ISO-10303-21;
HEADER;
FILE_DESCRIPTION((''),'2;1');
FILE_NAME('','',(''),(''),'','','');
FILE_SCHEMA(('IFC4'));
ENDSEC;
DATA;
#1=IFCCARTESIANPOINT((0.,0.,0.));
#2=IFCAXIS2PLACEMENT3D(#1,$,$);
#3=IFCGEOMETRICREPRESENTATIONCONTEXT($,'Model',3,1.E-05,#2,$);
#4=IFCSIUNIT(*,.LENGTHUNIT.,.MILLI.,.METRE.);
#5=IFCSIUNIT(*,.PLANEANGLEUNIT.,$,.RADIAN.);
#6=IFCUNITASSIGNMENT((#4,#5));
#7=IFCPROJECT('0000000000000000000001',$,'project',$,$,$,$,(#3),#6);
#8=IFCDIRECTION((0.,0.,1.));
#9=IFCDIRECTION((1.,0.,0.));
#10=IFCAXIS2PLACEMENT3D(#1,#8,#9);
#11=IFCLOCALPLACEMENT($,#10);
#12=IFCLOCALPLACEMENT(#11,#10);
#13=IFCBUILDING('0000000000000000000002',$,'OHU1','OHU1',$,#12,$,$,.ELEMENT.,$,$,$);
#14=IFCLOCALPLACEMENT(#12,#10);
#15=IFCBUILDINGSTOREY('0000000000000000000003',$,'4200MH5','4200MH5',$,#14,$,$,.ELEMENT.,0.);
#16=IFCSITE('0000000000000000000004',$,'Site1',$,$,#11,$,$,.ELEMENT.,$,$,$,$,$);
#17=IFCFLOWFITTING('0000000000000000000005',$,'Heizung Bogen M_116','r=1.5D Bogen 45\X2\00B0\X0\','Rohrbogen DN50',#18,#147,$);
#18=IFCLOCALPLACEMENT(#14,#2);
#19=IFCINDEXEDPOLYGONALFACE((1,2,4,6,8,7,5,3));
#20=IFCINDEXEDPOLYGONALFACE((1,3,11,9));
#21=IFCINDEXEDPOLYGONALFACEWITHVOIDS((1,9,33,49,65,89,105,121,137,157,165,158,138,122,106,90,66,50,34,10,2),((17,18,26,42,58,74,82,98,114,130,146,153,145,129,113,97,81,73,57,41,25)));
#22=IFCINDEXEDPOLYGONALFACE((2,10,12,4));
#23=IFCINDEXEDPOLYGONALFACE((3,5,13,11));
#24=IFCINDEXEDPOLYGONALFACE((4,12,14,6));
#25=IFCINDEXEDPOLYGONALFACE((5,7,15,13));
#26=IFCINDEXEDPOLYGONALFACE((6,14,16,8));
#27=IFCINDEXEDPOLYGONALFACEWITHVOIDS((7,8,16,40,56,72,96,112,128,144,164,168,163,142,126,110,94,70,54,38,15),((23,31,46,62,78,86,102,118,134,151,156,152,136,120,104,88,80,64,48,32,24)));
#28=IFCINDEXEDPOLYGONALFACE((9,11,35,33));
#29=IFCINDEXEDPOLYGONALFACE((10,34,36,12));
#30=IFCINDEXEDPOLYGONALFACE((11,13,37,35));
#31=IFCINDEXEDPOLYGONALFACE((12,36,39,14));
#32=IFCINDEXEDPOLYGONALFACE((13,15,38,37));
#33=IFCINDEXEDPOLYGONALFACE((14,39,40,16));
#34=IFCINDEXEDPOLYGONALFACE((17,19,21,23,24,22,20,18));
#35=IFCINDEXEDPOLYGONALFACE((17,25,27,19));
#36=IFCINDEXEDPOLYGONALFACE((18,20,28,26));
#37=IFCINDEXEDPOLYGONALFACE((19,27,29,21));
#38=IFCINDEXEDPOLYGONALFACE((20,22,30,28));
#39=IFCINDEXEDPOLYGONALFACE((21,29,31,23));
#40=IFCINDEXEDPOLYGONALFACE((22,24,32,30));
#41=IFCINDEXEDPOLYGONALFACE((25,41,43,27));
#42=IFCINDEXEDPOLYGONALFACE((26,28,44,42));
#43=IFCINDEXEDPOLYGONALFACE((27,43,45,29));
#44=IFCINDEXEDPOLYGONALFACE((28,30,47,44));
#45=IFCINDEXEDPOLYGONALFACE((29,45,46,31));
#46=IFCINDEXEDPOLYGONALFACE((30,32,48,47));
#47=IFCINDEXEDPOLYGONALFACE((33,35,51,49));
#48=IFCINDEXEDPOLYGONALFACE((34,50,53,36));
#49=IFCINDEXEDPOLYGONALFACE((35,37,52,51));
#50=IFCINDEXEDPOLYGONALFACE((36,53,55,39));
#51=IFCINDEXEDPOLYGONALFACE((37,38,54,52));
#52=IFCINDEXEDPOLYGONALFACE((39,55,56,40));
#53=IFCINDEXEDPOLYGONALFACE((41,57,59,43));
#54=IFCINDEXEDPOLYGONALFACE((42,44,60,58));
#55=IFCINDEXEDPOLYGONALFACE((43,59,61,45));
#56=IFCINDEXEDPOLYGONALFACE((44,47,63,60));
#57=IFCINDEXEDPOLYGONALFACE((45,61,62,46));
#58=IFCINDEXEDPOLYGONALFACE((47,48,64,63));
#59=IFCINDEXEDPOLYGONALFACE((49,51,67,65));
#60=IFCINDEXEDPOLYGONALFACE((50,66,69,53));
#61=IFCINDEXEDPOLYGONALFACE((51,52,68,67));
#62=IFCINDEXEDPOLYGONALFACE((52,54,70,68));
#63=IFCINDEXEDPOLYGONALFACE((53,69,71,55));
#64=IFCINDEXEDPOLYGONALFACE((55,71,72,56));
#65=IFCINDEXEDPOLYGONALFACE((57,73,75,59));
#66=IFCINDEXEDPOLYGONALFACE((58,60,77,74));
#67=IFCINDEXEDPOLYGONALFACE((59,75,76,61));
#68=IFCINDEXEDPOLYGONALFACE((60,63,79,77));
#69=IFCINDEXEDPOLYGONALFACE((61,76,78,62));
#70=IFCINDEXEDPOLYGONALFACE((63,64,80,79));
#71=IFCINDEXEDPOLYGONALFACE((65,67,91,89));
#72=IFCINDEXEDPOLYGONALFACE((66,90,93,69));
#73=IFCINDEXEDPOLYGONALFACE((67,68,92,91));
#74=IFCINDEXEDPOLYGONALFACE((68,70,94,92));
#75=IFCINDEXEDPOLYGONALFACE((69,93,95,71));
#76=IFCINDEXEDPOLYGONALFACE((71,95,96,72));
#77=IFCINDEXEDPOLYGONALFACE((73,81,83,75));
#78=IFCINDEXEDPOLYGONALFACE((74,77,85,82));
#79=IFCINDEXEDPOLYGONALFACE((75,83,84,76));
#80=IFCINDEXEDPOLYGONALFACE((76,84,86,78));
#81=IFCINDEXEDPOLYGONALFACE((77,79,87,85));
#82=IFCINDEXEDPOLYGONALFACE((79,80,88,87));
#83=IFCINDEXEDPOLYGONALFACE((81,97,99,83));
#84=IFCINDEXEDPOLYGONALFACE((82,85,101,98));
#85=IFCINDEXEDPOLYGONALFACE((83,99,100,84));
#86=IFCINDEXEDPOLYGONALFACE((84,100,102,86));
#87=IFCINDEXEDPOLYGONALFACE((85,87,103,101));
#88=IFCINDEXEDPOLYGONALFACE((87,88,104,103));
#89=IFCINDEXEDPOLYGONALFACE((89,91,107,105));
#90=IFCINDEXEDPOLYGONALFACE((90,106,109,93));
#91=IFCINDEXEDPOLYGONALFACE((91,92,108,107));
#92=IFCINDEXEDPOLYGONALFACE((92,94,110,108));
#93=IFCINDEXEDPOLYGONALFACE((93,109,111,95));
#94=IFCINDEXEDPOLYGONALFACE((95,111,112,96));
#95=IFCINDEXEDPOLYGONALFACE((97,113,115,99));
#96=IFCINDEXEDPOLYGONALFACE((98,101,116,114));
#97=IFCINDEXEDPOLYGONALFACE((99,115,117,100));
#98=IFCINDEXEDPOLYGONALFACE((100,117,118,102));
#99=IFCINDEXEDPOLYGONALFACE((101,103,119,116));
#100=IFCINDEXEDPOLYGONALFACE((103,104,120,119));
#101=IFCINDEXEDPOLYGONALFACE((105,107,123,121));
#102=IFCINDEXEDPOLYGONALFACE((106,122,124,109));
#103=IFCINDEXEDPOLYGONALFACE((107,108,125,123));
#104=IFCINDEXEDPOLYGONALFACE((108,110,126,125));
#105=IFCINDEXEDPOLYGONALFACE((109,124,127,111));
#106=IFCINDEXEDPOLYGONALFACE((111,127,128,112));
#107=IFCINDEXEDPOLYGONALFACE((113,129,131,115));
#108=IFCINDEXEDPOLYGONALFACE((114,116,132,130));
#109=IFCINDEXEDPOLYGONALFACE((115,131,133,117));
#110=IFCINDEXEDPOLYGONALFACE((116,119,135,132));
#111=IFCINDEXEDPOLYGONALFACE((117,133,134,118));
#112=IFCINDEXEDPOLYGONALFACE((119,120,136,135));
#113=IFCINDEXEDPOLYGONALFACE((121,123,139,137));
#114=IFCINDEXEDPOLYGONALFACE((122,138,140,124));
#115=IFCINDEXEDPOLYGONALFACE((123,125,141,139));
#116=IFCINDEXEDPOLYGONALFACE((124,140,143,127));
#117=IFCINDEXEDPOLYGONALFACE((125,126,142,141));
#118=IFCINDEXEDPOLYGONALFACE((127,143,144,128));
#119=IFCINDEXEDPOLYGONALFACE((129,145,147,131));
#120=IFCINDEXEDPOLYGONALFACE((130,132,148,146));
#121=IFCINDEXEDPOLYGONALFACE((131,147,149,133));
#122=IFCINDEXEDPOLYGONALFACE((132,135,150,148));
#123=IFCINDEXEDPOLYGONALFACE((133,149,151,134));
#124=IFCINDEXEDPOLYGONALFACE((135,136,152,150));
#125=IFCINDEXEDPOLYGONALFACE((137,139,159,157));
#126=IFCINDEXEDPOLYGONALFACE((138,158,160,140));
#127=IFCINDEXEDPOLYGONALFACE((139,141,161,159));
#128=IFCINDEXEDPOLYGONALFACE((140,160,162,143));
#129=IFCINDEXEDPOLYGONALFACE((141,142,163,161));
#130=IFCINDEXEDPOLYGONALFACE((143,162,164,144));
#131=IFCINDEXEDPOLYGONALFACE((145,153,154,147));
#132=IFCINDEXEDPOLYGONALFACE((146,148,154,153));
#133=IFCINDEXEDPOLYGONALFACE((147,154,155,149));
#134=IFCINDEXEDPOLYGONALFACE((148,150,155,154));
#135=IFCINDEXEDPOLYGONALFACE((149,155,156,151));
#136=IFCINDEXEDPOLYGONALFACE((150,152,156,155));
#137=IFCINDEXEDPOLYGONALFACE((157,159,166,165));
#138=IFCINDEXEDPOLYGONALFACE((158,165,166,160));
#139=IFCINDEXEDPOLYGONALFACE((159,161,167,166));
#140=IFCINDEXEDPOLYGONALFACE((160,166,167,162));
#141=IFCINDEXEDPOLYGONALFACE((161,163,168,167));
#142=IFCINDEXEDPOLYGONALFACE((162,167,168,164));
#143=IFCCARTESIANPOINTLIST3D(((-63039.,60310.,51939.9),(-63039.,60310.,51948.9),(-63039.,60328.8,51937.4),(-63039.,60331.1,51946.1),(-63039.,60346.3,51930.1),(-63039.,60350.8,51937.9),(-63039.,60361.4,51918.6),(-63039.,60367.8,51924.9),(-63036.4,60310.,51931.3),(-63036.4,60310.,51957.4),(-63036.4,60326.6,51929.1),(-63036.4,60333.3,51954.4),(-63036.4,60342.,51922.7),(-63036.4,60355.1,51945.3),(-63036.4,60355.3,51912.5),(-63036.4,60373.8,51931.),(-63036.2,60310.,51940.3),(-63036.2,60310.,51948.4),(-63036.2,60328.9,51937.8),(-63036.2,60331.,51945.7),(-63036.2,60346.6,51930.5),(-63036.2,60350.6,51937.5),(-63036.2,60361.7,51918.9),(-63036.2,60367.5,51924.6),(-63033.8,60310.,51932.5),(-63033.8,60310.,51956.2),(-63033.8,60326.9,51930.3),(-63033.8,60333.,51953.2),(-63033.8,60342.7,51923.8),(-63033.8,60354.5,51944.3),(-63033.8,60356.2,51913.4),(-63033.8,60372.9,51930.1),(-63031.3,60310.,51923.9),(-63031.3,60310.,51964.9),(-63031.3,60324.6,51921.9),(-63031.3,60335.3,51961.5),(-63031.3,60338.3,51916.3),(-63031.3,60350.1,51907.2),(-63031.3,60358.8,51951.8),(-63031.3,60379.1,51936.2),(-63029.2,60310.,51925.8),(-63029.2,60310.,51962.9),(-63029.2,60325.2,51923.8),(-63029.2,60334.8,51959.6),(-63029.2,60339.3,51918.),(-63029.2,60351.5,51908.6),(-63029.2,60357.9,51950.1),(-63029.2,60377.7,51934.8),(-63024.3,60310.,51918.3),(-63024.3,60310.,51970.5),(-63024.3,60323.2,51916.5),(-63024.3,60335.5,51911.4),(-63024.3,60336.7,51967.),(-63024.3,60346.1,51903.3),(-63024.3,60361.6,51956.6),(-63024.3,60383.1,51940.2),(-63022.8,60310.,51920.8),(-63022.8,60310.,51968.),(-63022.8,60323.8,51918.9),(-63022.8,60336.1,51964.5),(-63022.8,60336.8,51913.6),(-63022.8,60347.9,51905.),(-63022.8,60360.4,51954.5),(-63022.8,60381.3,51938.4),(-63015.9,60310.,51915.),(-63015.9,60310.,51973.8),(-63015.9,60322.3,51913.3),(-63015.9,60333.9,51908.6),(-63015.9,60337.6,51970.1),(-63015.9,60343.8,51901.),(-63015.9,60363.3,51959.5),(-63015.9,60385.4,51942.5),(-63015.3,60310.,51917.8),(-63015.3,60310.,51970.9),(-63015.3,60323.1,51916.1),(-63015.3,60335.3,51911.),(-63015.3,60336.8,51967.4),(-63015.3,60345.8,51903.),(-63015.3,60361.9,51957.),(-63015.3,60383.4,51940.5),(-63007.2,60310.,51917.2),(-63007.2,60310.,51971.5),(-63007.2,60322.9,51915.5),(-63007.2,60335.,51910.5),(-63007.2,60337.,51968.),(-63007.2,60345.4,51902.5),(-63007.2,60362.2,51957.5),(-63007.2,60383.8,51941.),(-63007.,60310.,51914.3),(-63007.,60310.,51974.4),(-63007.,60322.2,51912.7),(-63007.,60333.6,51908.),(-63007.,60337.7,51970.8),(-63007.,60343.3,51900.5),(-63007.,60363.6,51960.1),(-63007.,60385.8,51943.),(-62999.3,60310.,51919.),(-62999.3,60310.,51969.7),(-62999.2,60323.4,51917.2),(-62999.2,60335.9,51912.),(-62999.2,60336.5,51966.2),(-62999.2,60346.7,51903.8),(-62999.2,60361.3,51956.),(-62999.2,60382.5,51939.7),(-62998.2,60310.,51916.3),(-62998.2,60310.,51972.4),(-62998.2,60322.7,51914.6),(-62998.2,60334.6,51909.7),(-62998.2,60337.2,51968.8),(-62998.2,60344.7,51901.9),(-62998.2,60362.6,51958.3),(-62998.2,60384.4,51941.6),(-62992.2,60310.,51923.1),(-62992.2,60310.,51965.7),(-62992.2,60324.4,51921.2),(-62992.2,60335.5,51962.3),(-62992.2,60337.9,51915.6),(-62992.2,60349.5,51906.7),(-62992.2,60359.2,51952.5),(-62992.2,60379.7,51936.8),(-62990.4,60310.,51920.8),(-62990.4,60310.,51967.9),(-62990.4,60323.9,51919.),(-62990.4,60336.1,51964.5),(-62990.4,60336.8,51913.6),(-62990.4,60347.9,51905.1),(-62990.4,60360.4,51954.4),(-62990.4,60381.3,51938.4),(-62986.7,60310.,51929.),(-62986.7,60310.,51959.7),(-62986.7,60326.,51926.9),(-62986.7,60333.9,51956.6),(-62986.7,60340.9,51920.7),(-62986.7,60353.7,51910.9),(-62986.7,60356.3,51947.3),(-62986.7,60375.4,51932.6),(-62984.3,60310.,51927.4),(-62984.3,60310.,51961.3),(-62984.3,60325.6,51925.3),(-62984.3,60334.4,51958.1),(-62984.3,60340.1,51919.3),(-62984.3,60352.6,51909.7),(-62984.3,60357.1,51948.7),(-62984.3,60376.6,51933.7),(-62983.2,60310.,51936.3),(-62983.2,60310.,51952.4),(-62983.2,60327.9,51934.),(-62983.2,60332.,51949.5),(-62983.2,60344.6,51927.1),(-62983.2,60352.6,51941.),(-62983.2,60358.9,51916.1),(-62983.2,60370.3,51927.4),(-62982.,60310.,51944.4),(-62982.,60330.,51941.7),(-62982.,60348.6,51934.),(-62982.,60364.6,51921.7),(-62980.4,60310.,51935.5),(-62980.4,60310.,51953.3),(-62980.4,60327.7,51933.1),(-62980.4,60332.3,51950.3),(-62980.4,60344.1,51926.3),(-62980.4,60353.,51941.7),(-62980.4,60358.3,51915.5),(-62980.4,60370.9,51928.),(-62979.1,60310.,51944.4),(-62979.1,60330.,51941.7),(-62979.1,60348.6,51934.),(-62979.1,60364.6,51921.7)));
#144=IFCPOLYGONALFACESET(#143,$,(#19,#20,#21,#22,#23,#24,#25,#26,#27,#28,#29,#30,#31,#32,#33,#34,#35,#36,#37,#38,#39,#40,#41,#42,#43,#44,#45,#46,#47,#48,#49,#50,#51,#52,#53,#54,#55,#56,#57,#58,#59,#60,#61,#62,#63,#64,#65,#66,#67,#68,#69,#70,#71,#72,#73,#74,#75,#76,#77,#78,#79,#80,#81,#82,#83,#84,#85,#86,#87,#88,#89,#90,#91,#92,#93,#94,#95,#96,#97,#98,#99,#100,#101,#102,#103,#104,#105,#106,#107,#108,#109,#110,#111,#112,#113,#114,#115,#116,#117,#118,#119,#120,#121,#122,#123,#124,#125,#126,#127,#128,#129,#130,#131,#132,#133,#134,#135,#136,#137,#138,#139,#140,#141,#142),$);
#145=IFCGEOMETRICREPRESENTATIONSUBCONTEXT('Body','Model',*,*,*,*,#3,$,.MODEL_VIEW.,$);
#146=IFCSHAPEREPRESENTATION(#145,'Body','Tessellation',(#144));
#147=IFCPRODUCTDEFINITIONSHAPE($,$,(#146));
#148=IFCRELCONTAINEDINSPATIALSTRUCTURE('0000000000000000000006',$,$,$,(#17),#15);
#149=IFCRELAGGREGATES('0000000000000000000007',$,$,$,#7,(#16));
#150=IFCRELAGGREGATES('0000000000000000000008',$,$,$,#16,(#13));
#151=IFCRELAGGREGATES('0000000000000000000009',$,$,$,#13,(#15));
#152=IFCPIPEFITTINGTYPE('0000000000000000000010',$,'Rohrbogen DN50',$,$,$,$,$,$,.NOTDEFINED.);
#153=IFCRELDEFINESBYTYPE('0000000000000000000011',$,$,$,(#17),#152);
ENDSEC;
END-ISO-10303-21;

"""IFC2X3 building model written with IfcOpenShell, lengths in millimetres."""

from ifc_helpers import new_model, entity, si_unit, frame, origin, origin_with_axes, place, context, subcontext, project, spatial, type_object, element, save


model = new_model("IFC2X3")

# Units and contexts
model_context = context("Model", 3, precision=1e-05, world=origin())
body_context = subcontext(model_context, "Body", "Model", "MODEL_VIEW")
ifc_project = project(units=[si_unit("LENGTHUNIT", "METRE", prefix="MILLI"), si_unit("PLANEANGLEUNIT", "RADIAN")], contexts=[model_context])

# Site, building, storey
site_placement = place(None, origin_with_axes())
site = spatial("IfcSite", under=ifc_project, at=site_placement, Name="Site1", CompositionType="ELEMENT")
building_placement = place(site_placement, origin_with_axes())
building = spatial("IfcBuilding", under=site, at=building_placement, Name="OHU1", Description="OHU1", CompositionType="ELEMENT")
storey_placement = place(building_placement, origin_with_axes())
storey = spatial("IfcBuildingStorey", under=building, at=storey_placement, Name="4200MH5", Description="4200MH5", CompositionType="ELEMENT", Elevation=0.0)

# Flow fitting
pipe_fitting_type_1 = type_object("IfcPipeFittingType", Name="Rohrbogen DN50", PredefinedType="NOTDEFINED")
flow_fitting_1_placement = place(storey_placement, frame((-63009.2, 60362.9, 51944.4), z_axis=(0.0, 0.0, 1.0), x_axis=(1.0, 0.0, 0.0)))
element("IfcFlowFitting", 1, at=flow_fitting_1_placement, inside=storey, type_object=pipe_fitting_type_1, Name="Heizung Bogen M_116", Description="r=1.5D Bogen 45°", ObjectType="Rohrbogen DN50", context=body_context, shape_type="SweptSolid", body=[
    entity("IfcRevolvedAreaSolid", entity("IfcCircleHollowProfileDef", "AREA", None, entity("IfcAxis2Placement2D", entity("IfcCartesianPoint", [0.0, 0.0]), entity("IfcDirection", [1.0, 0.0])), 30.1, 2.9), entity("IfcAxis2Placement3D", entity("IfcCartesianPoint", [0.0, -52.9, 0.0]), entity("IfcDirection", [0.000003, 1.0, 0.0]), entity("IfcDirection", [1.0, -0.000003, 0.0])), entity("IfcAxis1Placement", entity("IfcCartesianPoint", [0.0, 77.3, 0.0]), entity("IfcDirection", [-1.0, 0.0, 0.0])), 0.785398),
])

save(model, "model.ifc")
